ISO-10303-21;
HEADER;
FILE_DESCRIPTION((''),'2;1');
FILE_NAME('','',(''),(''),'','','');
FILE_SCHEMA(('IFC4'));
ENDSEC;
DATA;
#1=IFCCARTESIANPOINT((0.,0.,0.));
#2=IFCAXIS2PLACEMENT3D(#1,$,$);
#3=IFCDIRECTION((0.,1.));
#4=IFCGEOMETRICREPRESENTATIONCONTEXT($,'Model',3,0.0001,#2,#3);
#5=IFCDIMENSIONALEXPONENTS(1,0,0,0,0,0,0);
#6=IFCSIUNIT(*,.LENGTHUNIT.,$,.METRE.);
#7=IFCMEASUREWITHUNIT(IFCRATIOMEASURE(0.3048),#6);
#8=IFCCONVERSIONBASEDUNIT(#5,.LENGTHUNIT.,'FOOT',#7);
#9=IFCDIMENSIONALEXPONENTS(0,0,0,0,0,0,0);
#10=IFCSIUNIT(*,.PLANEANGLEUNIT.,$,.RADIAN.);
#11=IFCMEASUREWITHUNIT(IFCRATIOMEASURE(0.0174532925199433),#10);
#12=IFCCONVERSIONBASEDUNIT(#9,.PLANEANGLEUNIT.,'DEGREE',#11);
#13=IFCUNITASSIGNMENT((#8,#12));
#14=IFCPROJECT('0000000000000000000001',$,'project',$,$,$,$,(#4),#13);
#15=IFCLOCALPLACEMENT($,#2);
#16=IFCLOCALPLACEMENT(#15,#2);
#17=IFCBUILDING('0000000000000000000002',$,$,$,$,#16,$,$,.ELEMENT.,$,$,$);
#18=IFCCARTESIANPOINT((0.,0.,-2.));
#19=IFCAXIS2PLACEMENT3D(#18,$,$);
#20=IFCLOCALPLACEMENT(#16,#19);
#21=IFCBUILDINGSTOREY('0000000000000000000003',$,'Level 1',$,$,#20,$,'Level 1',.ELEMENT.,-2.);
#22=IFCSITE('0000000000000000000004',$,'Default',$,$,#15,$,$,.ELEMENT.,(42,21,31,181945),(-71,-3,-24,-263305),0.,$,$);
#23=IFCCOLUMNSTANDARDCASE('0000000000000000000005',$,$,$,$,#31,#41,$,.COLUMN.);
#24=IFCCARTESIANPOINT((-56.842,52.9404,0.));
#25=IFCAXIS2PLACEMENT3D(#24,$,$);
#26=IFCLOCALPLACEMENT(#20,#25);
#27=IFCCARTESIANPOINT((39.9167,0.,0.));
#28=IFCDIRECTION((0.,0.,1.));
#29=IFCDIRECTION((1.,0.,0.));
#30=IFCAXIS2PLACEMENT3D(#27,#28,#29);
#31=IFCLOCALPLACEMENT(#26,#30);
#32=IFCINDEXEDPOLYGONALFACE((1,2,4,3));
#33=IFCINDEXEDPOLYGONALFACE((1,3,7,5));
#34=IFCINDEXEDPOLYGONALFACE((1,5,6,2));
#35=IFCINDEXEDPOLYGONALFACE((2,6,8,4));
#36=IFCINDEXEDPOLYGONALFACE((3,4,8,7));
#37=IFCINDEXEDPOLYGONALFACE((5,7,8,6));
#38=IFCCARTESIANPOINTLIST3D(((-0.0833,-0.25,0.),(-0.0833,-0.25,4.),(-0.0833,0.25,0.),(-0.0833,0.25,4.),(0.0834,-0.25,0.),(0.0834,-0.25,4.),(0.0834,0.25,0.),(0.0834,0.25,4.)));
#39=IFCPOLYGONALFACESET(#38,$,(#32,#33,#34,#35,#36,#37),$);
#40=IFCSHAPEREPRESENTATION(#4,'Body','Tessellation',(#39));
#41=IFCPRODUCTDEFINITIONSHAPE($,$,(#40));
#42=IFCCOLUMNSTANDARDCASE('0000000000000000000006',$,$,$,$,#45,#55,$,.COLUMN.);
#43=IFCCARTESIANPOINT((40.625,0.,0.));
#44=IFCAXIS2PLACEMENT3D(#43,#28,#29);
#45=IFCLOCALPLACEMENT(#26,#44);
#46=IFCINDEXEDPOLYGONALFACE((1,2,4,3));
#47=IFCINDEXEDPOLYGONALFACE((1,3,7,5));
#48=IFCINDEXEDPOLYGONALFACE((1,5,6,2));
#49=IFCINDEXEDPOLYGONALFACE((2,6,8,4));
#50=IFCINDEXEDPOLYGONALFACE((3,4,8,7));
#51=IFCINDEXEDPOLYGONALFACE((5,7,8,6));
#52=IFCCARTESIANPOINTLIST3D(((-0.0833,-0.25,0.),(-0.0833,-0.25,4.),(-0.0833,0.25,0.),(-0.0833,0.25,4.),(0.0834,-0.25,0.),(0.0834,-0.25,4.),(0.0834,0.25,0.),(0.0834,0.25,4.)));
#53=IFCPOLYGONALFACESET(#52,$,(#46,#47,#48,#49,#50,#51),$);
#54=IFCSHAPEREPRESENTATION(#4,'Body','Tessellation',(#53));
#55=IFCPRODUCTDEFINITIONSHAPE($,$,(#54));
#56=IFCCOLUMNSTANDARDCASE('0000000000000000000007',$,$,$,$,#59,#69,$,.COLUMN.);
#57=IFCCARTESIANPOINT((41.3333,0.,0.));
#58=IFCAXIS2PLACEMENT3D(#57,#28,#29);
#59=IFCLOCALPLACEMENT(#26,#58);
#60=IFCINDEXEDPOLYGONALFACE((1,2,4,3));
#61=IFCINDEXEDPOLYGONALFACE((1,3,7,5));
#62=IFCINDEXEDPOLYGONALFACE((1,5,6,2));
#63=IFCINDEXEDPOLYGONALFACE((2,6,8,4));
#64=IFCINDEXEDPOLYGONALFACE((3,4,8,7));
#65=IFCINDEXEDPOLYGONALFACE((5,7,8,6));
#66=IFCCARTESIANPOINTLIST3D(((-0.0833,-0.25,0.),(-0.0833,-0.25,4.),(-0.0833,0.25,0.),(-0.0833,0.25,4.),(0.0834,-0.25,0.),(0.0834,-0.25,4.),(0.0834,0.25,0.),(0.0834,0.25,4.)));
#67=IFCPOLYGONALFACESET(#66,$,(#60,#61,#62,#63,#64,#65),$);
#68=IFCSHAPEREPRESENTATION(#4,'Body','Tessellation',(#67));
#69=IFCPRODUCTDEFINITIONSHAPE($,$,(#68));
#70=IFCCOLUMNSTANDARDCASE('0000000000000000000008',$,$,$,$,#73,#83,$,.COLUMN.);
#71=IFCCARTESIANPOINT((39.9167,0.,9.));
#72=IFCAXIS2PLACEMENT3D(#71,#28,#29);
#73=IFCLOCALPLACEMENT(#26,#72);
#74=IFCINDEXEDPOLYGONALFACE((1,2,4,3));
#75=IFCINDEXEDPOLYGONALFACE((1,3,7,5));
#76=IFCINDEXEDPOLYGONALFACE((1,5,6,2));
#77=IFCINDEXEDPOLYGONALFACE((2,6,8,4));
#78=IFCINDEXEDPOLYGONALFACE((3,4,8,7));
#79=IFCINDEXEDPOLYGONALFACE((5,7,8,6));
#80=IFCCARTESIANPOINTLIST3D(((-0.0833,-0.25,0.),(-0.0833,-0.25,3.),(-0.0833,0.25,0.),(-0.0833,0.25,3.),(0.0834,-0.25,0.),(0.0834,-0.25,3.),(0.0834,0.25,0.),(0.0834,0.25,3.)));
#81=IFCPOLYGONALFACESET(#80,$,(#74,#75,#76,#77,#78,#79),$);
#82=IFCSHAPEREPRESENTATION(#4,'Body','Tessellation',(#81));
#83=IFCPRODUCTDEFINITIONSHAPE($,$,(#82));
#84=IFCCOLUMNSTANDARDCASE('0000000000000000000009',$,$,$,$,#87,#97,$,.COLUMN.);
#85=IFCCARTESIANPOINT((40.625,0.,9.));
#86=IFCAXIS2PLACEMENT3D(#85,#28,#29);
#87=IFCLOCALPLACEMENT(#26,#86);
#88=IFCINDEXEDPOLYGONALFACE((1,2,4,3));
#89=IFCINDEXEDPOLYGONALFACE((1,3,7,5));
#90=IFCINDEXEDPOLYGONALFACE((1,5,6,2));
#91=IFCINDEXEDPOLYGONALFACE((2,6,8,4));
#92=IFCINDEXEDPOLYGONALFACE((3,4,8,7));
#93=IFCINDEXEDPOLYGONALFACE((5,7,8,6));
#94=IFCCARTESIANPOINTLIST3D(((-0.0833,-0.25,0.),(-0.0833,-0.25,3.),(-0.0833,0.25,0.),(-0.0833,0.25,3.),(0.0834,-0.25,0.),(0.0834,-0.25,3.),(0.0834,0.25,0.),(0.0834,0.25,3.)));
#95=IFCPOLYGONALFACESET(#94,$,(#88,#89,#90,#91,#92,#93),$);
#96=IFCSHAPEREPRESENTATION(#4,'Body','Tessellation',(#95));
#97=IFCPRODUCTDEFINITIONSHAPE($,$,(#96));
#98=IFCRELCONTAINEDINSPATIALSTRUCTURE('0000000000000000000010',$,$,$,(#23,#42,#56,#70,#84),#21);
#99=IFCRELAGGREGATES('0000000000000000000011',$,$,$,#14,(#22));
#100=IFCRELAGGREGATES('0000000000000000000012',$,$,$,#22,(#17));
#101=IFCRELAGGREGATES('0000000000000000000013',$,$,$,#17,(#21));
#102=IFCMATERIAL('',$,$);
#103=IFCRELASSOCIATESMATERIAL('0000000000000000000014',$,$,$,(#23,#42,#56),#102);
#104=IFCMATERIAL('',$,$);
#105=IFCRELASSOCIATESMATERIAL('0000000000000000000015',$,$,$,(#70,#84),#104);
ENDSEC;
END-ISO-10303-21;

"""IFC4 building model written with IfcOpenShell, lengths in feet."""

from ifc_helpers import new_model, entity, si_unit, converted_unit, direction, frame, origin, place, context, project, spatial, rectangle, extrude, material, element, save


model = new_model("IFC4")

# Units and contexts
model_context = context("Model", 3, precision=0.0001, world=origin(), true_north=direction((0.0, 1.0)))
ifc_project = project(units=[converted_unit("LENGTHUNIT", "FOOT", entity("IfcRatioMeasure", 0.3048), si_unit("LENGTHUNIT", "METRE"), dimensions=[1, 0, 0, 0, 0, 0, 0]), converted_unit("PLANEANGLEUNIT", "DEGREE", entity("IfcRatioMeasure", 0.0174532925199433), si_unit("PLANEANGLEUNIT", "RADIAN"), dimensions=[0, 0, 0, 0, 0, 0, 0])], contexts=[model_context])

# Site, building, storey
site_placement = place(None, origin())
site = spatial("IfcSite", under=ifc_project, at=site_placement, Name="Default", CompositionType="ELEMENT", RefLatitude=(42, 21, 31, 181945), RefLongitude=(-71, -3, -24, -263305), RefElevation=0.0)
building_placement = place(site_placement, origin())
building = spatial("IfcBuilding", under=site, at=building_placement, CompositionType="ELEMENT")
storey_placement = place(building_placement, frame((0.0, 0.0, -2.0)))
storey = spatial("IfcBuildingStorey", under=building, at=storey_placement, Name="Level 1", LongName="Level 1", CompositionType="ELEMENT", Elevation=-2.0)

# Columns
ifc_material_1 = material(Name="")
placement = place(storey_placement, frame((-56.842, 52.9404, 0.0)))
for number, where, z_axis, x_axis in (
    (1, (39.9167, 0.0, 0.0), (0.0, 0.0, 1.0), (1.0, 0.0, 0.0)),
    (2, (40.625, 0.0, 0.0), (0.0, 0.0, 1.0), (1.0, 0.0, 0.0)),
    (3, (41.3333, 0.0, 0.0), (0.0, 0.0, 1.0), (1.0, 0.0, 0.0)),
):
    element("IfcColumnStandardCase", number, at=place(placement, frame(where, z_axis=z_axis, x_axis=x_axis)), inside=storey, material=ifc_material_1, PredefinedType="COLUMN", context=model_context, shape_type="SweptSolid", body=[
        extrude(rectangle(XDim=0.1667, YDim=0.5), origin(), (0.0, 0.0, 1.0), 4.0),
    ])
ifc_material_2 = material(Name="")
for number, where, z_axis, x_axis in (
    (4, (39.9167, 0.0, 9.0), (0.0, 0.0, 1.0), (1.0, 0.0, 0.0)),
    (5, (40.625, 0.0, 9.0), (0.0, 0.0, 1.0), (1.0, 0.0, 0.0)),
):
    element("IfcColumnStandardCase", number, at=place(placement, frame(where, z_axis=z_axis, x_axis=x_axis)), inside=storey, material=ifc_material_2, PredefinedType="COLUMN", context=model_context, shape_type="SweptSolid", body=[
        extrude(rectangle(XDim=0.1667, YDim=0.5), origin(), (0.0, 0.0, 1.0), 3.0),
    ])

save(model, "model.ifc")
